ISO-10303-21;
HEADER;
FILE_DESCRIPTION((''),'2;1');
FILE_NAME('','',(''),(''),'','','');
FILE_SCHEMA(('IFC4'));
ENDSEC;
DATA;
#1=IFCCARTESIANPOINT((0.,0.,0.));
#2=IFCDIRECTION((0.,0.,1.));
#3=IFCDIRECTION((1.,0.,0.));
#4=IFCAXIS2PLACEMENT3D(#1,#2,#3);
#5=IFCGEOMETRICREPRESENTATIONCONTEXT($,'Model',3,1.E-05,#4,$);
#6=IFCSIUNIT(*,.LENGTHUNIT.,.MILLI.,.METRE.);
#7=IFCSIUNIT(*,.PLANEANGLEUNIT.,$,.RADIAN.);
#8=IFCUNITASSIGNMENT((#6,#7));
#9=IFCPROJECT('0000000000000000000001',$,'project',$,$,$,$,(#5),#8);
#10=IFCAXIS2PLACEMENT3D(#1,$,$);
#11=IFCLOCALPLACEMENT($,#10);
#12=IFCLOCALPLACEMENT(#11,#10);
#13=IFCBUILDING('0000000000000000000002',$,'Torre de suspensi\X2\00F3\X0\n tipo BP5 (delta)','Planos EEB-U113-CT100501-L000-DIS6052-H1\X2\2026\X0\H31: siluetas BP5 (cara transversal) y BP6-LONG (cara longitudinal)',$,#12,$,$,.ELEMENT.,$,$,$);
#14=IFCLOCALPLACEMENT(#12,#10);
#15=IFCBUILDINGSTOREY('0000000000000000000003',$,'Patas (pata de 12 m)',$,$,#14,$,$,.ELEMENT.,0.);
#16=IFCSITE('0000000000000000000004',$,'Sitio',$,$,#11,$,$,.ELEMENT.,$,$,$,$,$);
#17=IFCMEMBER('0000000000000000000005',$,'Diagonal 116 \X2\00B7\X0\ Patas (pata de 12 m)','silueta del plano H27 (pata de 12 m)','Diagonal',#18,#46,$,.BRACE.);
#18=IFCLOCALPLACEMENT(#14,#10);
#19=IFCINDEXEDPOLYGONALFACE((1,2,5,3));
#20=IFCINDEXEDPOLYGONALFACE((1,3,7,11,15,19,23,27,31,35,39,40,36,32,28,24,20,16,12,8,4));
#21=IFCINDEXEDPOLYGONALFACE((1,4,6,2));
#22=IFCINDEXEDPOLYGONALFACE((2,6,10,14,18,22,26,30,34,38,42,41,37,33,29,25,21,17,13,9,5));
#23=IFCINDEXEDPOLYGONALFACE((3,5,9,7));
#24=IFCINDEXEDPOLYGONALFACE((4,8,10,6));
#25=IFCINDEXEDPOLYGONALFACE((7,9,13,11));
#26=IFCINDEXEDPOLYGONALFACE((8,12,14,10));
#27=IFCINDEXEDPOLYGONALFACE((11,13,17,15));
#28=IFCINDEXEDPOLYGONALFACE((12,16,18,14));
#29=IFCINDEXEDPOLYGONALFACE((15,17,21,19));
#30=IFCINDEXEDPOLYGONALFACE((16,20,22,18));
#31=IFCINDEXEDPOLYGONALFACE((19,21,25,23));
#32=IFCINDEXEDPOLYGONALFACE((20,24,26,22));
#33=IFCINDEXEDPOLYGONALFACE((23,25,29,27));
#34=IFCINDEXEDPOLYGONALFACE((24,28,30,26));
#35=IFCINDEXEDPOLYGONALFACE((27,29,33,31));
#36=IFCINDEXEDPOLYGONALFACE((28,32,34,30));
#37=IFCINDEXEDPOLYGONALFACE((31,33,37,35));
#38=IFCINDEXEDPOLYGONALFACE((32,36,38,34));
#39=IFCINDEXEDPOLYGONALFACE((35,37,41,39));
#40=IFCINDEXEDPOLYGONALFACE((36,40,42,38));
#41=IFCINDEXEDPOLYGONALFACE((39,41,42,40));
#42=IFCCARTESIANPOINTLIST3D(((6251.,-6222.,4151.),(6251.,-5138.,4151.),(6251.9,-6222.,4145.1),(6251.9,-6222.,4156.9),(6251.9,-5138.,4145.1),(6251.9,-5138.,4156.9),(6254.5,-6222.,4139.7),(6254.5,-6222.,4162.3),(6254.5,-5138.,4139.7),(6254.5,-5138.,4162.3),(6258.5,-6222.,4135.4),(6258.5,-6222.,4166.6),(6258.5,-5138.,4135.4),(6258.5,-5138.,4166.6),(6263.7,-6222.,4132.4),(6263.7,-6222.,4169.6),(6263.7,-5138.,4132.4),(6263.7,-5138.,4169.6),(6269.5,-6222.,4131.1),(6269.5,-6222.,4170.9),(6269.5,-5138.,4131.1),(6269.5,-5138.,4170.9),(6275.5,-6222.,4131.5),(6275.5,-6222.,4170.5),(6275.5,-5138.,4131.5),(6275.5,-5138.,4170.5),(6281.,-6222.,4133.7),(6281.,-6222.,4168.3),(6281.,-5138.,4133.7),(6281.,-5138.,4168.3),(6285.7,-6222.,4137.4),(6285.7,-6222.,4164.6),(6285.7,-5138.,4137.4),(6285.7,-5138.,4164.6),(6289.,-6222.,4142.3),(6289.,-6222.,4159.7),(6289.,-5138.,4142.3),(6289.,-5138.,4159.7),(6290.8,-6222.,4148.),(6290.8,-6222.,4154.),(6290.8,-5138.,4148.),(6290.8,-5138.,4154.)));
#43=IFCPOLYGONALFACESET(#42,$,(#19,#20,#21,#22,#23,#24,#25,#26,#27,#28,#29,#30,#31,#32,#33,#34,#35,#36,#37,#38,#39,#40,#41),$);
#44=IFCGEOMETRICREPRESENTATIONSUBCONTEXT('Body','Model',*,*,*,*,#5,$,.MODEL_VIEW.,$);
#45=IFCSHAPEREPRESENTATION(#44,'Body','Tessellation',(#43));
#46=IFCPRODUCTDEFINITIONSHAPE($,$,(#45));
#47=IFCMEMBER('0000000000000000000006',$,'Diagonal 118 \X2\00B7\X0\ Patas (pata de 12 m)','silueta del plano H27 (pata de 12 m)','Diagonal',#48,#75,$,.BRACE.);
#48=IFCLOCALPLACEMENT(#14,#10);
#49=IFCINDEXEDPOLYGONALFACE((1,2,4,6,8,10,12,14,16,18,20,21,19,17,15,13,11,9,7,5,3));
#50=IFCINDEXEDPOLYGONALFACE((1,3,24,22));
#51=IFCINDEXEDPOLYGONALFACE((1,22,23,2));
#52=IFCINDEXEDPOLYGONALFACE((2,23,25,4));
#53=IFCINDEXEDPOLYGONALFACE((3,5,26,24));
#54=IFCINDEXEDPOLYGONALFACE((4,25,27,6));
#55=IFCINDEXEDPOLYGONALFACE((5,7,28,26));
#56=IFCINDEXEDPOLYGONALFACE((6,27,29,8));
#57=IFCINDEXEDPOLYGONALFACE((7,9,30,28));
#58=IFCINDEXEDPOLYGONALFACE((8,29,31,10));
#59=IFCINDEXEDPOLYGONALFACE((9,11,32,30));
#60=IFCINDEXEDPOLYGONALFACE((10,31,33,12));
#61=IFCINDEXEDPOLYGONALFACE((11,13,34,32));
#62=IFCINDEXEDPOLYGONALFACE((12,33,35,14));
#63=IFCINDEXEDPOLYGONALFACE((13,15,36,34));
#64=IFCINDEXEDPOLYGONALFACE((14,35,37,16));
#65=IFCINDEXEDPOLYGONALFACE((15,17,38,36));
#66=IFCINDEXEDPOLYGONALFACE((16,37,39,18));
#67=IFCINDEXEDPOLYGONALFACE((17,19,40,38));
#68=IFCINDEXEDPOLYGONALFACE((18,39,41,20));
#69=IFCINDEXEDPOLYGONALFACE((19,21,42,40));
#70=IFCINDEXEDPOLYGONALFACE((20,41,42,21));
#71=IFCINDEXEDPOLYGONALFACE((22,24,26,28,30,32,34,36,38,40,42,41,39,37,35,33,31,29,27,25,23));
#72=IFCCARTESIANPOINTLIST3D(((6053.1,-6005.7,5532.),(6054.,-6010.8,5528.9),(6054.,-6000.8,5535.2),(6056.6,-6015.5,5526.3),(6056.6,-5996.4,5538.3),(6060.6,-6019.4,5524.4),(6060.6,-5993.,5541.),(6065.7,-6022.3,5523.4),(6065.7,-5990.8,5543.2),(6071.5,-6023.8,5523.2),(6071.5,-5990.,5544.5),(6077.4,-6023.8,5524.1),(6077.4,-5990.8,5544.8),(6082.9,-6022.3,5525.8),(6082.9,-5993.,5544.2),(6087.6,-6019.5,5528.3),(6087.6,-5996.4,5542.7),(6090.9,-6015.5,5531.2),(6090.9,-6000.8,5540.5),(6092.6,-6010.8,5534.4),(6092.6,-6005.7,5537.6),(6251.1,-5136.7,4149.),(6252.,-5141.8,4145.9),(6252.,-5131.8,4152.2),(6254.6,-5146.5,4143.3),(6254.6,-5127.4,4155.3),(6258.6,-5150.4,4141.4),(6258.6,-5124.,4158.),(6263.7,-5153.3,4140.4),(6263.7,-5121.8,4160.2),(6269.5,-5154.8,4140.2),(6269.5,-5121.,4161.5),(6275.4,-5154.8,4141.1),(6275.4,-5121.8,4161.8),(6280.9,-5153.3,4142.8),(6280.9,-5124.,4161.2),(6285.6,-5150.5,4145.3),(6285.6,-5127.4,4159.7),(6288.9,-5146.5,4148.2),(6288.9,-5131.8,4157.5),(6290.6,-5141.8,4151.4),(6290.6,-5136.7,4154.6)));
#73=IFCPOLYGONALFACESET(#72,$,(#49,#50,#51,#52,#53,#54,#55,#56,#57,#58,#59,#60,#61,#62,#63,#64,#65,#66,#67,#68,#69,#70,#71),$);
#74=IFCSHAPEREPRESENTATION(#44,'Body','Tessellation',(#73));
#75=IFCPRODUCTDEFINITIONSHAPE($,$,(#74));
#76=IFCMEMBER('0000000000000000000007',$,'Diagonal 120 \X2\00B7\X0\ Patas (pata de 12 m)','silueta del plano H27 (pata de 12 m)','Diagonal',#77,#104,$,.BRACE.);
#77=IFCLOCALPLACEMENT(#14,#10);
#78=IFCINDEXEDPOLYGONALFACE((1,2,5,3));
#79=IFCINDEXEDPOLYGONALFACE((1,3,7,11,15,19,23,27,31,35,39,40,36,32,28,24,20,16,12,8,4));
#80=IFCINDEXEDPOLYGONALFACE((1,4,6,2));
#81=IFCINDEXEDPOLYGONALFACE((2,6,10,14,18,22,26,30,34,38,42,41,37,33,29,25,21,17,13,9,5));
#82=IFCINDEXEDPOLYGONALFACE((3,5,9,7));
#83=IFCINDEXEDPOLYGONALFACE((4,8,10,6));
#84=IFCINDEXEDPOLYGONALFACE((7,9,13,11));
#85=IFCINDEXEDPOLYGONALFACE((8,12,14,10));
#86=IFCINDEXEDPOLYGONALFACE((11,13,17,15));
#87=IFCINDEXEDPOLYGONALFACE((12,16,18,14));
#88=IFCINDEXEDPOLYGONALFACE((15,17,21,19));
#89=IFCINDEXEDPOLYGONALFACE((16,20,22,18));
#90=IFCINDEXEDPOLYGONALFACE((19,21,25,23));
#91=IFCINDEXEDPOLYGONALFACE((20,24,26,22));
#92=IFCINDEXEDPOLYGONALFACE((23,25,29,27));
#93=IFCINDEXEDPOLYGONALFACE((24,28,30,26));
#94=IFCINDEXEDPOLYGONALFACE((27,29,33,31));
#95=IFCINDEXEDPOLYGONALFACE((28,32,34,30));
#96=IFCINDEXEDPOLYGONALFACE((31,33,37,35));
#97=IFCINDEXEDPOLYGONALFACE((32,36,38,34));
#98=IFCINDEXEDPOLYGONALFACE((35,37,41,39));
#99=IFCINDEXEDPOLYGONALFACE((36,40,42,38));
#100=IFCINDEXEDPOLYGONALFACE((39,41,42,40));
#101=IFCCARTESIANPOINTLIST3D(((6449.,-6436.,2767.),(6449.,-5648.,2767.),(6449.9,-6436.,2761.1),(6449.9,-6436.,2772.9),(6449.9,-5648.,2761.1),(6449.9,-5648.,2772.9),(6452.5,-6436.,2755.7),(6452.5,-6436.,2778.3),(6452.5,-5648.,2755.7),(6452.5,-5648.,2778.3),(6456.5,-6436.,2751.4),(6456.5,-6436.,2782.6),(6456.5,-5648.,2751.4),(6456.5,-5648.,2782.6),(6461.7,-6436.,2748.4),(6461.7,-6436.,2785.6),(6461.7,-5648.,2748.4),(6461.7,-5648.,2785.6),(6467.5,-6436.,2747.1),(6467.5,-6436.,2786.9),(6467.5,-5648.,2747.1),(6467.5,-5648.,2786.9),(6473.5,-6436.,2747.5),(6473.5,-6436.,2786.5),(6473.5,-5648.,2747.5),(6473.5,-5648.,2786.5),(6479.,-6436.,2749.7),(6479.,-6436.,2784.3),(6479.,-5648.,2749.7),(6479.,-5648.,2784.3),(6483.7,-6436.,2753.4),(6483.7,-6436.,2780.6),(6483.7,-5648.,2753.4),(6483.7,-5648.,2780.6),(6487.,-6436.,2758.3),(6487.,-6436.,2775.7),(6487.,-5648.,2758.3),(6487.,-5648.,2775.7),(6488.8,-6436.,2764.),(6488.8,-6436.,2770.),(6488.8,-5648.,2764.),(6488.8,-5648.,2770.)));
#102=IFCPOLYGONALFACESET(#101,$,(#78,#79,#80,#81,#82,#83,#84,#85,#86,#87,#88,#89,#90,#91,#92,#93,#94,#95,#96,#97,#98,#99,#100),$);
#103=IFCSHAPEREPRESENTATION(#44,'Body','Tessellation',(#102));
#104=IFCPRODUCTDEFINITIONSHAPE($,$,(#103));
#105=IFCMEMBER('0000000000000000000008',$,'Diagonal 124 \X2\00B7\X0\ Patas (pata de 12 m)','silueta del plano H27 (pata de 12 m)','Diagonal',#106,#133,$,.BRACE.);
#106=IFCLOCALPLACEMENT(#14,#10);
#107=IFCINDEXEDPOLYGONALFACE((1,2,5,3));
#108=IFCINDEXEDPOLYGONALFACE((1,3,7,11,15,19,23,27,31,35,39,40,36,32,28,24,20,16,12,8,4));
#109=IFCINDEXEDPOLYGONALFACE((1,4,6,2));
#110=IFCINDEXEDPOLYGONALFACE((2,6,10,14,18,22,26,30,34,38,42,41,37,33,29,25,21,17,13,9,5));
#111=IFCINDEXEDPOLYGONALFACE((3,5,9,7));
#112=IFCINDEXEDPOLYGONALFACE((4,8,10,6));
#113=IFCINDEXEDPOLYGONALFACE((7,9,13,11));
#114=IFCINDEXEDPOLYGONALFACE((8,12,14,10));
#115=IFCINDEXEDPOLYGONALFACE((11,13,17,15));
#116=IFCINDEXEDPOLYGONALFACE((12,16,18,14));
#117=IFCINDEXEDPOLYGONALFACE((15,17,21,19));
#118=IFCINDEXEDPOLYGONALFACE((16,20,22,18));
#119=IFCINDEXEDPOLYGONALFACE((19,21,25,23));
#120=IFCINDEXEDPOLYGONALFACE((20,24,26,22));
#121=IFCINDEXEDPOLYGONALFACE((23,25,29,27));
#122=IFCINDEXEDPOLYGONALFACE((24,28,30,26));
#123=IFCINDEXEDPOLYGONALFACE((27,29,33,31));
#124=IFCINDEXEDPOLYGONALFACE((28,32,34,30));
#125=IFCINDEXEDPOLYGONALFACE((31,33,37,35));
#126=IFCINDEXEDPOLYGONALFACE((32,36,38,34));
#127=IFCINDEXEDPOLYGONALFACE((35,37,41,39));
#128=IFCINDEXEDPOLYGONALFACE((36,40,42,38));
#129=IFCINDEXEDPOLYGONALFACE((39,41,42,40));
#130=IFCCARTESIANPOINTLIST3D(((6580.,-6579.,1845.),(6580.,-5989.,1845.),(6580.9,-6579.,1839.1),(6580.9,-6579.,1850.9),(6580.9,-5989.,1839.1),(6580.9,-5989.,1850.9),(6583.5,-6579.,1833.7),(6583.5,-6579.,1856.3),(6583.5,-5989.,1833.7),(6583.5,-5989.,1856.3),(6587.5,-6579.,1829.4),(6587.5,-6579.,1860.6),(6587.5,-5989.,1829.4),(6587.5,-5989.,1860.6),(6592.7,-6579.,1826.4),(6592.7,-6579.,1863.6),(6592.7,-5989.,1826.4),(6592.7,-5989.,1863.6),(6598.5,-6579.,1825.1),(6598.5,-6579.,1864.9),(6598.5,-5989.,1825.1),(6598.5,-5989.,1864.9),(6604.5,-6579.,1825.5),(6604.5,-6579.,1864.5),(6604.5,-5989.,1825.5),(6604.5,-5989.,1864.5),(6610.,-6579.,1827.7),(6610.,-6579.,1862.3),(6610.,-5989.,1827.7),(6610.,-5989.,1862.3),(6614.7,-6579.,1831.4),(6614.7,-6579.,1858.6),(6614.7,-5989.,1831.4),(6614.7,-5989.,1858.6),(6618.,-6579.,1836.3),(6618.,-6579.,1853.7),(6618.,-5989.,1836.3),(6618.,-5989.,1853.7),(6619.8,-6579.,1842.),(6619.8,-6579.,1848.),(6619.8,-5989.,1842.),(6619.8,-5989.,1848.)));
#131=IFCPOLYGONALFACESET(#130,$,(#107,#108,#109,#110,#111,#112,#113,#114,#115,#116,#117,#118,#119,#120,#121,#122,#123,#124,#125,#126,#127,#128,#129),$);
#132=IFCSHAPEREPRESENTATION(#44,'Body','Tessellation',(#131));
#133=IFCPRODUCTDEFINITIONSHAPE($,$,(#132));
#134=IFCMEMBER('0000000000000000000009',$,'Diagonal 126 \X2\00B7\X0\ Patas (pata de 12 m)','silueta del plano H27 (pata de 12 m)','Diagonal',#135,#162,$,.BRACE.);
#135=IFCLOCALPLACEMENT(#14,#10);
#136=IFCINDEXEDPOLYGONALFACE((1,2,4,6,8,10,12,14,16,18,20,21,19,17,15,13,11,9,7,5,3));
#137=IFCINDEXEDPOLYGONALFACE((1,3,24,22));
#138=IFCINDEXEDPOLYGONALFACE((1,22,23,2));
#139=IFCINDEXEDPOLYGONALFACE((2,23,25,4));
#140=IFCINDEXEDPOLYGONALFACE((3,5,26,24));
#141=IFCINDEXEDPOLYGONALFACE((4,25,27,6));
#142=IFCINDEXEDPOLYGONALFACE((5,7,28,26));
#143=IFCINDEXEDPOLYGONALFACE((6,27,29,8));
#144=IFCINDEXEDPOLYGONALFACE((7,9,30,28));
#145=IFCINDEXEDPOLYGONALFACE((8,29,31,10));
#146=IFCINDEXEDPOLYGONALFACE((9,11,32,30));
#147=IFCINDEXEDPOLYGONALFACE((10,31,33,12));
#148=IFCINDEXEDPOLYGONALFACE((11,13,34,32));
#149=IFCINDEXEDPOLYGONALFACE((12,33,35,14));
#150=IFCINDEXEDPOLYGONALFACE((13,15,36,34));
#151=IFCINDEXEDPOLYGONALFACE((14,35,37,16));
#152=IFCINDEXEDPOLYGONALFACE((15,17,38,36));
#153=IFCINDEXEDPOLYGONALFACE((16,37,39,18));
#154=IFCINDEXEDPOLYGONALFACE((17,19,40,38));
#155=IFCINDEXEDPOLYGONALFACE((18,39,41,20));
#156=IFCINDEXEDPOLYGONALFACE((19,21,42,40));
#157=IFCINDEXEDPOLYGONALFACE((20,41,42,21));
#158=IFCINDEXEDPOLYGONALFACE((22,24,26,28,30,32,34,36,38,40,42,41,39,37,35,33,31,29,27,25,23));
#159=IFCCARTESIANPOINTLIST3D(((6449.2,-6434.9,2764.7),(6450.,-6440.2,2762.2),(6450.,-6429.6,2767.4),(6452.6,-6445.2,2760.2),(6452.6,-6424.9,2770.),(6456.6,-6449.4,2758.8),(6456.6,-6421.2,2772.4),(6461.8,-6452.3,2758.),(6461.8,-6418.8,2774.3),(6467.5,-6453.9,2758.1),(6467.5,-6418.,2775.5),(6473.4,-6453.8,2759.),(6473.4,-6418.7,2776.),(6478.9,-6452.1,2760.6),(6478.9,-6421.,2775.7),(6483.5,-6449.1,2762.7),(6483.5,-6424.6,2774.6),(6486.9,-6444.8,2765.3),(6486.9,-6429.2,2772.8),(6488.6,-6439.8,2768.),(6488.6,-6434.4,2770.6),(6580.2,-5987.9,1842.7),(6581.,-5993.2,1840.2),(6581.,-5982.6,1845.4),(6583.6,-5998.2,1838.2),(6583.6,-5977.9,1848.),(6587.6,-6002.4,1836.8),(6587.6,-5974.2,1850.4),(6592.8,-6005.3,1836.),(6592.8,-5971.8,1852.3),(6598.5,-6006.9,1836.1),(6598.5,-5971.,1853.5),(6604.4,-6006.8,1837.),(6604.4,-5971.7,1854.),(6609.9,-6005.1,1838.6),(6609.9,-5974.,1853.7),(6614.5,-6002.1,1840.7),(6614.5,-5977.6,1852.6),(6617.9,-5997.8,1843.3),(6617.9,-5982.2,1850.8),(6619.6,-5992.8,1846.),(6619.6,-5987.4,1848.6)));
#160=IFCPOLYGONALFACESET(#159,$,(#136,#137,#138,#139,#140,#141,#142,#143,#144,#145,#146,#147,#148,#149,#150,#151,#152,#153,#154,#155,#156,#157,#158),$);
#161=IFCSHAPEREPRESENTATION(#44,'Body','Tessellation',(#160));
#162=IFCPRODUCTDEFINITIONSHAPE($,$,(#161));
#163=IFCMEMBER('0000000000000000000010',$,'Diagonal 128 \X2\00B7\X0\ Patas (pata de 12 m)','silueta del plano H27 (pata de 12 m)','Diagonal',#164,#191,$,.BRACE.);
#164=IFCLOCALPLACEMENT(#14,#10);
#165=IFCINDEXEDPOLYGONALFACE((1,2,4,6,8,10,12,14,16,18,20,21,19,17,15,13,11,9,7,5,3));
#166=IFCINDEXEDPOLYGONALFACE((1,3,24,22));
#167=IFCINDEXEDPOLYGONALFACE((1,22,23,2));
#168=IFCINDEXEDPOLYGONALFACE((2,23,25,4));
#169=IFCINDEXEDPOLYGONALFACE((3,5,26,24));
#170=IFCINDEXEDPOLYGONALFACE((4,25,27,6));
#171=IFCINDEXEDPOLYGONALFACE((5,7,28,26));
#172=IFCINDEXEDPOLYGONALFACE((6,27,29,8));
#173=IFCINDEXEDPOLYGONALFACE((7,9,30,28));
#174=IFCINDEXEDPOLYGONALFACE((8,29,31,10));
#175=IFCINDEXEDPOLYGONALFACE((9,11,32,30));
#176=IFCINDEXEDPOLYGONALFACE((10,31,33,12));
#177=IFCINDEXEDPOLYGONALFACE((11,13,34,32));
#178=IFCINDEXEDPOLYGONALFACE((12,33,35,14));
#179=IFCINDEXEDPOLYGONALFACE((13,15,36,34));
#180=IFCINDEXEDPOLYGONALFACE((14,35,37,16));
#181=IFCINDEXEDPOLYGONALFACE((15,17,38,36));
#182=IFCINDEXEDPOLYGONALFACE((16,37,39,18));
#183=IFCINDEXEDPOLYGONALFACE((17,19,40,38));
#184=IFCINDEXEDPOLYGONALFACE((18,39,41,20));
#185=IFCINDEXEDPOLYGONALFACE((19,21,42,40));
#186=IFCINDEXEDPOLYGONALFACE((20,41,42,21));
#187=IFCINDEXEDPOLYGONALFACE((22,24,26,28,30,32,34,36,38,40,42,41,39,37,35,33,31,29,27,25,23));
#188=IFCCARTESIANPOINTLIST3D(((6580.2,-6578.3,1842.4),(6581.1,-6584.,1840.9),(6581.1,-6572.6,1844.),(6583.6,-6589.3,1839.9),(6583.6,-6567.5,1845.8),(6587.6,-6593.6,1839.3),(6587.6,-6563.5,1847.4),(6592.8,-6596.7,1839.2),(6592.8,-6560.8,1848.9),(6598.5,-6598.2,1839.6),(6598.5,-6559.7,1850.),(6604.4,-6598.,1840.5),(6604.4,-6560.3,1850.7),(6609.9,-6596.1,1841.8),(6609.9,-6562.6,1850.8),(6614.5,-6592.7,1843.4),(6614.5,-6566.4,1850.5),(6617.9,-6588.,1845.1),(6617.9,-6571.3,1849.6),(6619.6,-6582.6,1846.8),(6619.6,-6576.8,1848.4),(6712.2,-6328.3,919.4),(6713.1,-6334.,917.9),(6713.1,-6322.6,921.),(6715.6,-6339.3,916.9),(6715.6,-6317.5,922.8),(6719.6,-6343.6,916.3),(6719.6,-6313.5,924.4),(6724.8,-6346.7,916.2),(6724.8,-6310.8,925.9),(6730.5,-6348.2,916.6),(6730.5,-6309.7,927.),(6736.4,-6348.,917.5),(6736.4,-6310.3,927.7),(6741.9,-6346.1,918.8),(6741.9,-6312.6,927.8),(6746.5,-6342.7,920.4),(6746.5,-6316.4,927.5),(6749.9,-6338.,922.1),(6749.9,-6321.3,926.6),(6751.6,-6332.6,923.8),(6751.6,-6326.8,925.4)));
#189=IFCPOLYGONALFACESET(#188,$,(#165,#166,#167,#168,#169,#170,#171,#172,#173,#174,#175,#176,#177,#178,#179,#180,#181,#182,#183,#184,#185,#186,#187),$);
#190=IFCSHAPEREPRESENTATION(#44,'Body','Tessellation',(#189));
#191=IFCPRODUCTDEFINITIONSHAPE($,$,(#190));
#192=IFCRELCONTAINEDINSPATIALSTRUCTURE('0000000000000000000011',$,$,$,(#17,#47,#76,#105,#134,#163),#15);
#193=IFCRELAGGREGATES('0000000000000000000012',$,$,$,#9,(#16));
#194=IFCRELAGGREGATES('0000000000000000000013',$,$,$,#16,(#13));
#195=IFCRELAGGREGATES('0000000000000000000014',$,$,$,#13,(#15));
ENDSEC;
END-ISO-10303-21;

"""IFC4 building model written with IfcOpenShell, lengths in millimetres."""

from ifc_helpers import new_model, si_unit, frame, origin, origin_with_axes, place, context, subcontext, project, spatial, circle, extrude, element, save


model = new_model("IFC4")

# Units and contexts
model_context = context("Model", 3, precision=1e-05, world=origin_with_axes())
body_context = subcontext(model_context, "Body", "Model", "MODEL_VIEW")
ifc_project = project(units=[si_unit("LENGTHUNIT", "METRE", prefix="MILLI"), si_unit("PLANEANGLEUNIT", "RADIAN")], contexts=[model_context])

# Site, building, storey
site_placement = place(None, origin())
site = spatial("IfcSite", under=ifc_project, at=site_placement, Name="Sitio", CompositionType="ELEMENT")
building_placement = place(site_placement, origin())
building = spatial("IfcBuilding", under=site, at=building_placement, Name="Torre de suspensión tipo BP5 (delta)", Description="Planos EEB-U113-CT100501-L000-DIS6052-H1…H31: siluetas BP5 (cara transversal) y BP6-LONG (cara longitudinal)", CompositionType="ELEMENT")
storey_placement = place(building_placement, origin())
storey = spatial("IfcBuildingStorey", under=building, at=storey_placement, Name="Patas (pata de 12 m)", CompositionType="ELEMENT", Elevation=0.0)

# Members
member_1_placement = place(storey_placement, frame((6271.0, -6222.0, 4151.0), z_axis=(0.0, 1.0, 0.0), x_axis=(-1.0, 0.0, 0.0)))
element("IfcMember", 1, at=member_1_placement, inside=storey, Name="Diagonal 116 · Patas (pata de 12 m)", Description="silueta del plano H27 (pata de 12 m)", ObjectType="Diagonal", PredefinedType="BRACE", context=body_context, shape_type="SweptSolid", body=[
    extrude(circle(Radius=20.0), None, (0.0, 0.0, 1.0), 1084.0),
])
member_2_placement = place(storey_placement, frame((6271.0, -5138.0, 4151.0), z_axis=(-0.120342, -0.528167, 0.84057), x_axis=(-0.992733, 0.064026, -0.101896)))
element("IfcMember", 2, at=member_2_placement, inside=storey, Name="Diagonal 118 · Patas (pata de 12 m)", Description="silueta del plano H27 (pata de 12 m)", ObjectType="Diagonal", PredefinedType="BRACE", context=body_context, shape_type="SweptSolid", body=[
    extrude(circle(Radius=20.0), None, (0.0, 0.0, 1.0), 1645.3),
])
member_3_placement = place(storey_placement, frame((6469.0, -6436.0, 2767.0), z_axis=(0.0, 1.0, 0.0), x_axis=(-1.0, 0.0, 0.0)))
element("IfcMember", 3, at=member_3_placement, inside=storey, Name="Diagonal 120 · Patas (pata de 12 m)", Description="silueta del plano H27 (pata de 12 m)", ObjectType="Diagonal", PredefinedType="BRACE", context=body_context, shape_type="SweptSolid", body=[
    extrude(circle(Radius=20.0), None, (0.0, 0.0, 1.0), 788.0),
])
member_4_placement = place(storey_placement, frame((6600.0, -6579.0, 1845.0), z_axis=(0.0, 1.0, 0.0), x_axis=(-1.0, 0.0, 0.0)))
element("IfcMember", 4, at=member_4_placement, inside=storey, Name="Diagonal 124 · Patas (pata de 12 m)", Description="silueta del plano H27 (pata de 12 m)", ObjectType="Diagonal", PredefinedType="BRACE", context=body_context, shape_type="SweptSolid", body=[
    extrude(circle(Radius=20.0), None, (0.0, 0.0, 1.0), 590.0),
])
member_5_placement = place(storey_placement, frame((6600.0, -5989.0, 1845.0), z_axis=(-0.126817, -0.432727, 0.892561), x_axis=(-0.991926, 0.055324, -0.114113)))
element("IfcMember", 5, at=member_5_placement, inside=storey, Name="Diagonal 126 · Patas (pata de 12 m)", Description="silueta del plano H27 (pata de 12 m)", ObjectType="Diagonal", PredefinedType="BRACE", context=body_context, shape_type="SweptSolid", body=[
    extrude(circle(Radius=20.0), None, (0.0, 0.0, 1.0), 1033.0),
])
member_6_placement = place(storey_placement, frame((6732.0, -6329.0, 922.0), z_axis=(-0.136741, -0.25898, 0.956154), x_axis=(-0.990607, 0.035749, -0.131986)))
element("IfcMember", 6, at=member_6_placement, inside=storey, Name="Diagonal 128 · Patas (pata de 12 m)", Description="silueta del plano H27 (pata de 12 m)", ObjectType="Diagonal", PredefinedType="BRACE", context=body_context, shape_type="SweptSolid", body=[
    extrude(circle(Radius=20.0), None, (0.0, 0.0, 1.0), 965.3),
])

save(model, "model.ifc")
